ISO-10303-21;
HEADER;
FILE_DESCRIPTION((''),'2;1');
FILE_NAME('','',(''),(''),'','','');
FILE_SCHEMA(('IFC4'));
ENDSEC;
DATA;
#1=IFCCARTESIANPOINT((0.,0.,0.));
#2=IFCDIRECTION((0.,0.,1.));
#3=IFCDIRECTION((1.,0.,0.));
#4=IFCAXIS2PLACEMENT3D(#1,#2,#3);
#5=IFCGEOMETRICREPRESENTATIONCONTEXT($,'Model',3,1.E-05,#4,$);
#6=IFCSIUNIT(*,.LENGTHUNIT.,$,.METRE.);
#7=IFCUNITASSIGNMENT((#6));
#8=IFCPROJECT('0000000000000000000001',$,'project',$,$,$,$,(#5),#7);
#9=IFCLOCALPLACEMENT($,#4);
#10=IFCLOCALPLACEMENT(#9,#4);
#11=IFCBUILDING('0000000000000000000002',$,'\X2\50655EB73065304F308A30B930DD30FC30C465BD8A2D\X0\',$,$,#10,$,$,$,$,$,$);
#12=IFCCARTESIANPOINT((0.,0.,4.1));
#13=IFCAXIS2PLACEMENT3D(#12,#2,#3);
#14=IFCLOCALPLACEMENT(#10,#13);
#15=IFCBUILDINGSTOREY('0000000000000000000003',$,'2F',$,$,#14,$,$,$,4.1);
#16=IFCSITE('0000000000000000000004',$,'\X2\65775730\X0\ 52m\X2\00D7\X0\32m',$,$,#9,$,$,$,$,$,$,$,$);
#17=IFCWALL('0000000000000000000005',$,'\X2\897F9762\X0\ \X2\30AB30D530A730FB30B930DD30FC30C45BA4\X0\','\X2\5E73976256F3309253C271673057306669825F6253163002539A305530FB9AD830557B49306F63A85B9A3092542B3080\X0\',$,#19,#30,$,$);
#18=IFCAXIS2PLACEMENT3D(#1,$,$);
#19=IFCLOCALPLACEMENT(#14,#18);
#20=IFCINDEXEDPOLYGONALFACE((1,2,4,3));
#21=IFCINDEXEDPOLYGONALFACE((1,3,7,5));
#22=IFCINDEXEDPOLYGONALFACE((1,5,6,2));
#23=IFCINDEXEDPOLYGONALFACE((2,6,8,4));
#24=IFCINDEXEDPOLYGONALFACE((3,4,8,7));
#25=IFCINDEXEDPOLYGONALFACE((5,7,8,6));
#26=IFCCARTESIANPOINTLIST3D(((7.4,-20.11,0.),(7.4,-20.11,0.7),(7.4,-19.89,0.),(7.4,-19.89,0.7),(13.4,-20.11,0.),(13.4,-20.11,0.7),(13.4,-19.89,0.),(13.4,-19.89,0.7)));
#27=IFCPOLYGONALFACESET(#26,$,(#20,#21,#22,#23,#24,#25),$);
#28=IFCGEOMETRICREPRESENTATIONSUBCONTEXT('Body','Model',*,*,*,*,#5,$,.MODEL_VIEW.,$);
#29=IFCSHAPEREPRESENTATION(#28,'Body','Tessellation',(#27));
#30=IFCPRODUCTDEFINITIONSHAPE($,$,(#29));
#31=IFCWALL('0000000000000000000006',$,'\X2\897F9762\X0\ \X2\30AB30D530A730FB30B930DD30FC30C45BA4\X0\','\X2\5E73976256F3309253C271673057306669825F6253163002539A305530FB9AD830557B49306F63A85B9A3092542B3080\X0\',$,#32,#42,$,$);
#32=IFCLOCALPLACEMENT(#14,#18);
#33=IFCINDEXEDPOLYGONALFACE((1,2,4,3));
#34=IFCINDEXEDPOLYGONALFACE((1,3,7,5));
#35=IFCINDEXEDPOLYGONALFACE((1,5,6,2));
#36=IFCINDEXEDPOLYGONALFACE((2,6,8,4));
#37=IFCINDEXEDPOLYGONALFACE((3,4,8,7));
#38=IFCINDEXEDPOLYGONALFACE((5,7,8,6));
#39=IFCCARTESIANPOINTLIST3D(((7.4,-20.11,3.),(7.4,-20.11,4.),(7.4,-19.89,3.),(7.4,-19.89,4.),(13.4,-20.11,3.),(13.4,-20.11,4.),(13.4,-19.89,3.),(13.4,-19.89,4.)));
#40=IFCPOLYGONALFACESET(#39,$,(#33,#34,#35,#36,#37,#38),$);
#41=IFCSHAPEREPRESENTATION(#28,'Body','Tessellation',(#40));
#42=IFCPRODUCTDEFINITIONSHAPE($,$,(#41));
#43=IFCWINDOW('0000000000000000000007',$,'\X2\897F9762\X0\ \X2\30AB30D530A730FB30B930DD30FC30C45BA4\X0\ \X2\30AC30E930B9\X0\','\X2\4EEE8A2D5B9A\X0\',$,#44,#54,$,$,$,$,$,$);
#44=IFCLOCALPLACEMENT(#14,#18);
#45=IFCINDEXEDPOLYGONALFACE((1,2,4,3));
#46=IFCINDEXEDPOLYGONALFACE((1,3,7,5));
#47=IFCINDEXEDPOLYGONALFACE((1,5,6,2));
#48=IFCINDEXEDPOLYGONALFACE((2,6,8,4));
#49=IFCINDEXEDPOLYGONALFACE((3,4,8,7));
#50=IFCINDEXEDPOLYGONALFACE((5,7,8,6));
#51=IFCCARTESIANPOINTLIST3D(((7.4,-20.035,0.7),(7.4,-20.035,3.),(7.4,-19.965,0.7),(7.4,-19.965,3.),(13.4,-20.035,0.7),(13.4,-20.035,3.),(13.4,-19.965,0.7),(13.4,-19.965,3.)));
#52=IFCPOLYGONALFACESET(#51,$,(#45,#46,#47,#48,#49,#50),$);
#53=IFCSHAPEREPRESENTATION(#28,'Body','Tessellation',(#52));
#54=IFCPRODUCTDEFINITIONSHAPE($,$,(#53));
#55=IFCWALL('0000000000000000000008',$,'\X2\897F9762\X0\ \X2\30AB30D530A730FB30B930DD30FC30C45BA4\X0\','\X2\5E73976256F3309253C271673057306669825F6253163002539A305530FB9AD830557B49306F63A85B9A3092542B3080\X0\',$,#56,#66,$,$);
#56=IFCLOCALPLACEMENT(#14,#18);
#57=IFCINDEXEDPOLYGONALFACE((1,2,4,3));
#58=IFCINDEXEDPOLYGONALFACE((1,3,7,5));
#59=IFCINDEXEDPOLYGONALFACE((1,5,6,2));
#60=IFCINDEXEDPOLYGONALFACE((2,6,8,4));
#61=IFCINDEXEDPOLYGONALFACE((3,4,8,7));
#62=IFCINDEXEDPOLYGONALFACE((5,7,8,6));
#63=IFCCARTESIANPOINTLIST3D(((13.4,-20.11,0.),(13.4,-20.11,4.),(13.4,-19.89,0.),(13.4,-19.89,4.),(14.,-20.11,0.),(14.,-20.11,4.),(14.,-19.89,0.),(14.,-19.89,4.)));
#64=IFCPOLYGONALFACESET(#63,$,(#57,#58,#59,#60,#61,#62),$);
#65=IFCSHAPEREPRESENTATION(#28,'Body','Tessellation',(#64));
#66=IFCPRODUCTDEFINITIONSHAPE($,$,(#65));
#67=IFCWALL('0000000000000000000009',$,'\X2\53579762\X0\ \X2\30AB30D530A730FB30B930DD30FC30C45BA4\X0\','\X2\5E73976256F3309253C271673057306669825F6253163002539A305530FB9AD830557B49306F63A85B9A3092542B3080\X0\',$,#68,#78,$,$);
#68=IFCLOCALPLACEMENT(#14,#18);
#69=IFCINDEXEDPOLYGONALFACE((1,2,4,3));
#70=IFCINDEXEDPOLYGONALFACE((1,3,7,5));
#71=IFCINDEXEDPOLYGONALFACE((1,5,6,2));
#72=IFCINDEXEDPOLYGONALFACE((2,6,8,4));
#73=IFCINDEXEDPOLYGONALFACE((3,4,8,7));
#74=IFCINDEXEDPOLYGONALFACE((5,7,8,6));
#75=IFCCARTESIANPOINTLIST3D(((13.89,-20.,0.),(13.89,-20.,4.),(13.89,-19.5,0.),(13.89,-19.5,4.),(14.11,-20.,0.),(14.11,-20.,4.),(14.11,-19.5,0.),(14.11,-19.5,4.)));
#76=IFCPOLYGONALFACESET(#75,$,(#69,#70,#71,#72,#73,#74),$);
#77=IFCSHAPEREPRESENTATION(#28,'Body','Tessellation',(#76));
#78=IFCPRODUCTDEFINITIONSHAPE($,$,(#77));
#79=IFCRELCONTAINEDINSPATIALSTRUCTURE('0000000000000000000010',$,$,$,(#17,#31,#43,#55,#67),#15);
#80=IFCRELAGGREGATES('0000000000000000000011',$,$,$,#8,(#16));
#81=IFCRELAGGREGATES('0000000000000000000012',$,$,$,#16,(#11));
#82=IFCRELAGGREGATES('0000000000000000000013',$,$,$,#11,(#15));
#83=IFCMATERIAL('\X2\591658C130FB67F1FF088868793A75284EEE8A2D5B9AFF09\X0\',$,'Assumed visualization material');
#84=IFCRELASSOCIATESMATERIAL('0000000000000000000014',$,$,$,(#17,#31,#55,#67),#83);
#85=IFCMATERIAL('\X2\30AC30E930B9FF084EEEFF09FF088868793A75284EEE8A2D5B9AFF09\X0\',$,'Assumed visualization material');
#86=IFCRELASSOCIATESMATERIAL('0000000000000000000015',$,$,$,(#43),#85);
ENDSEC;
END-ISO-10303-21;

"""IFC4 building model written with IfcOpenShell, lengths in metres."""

from ifc_helpers import new_model, si_unit, frame, origin_with_axes, place, context, subcontext, project, spatial, rectangle, extrude, material, element, save


model = new_model("IFC4")

# Units and contexts
model_context = context("Model", 3, precision=1e-05, world=origin_with_axes())
body_context = subcontext(model_context, "Body", "Model", "MODEL_VIEW")
ifc_project = project(units=[si_unit("LENGTHUNIT", "METRE")], contexts=[model_context])

# Site, building, storey
site_placement = place(None, origin_with_axes())
site = spatial("IfcSite", under=ifc_project, at=site_placement, Name="敷地 52m×32m")
building_placement = place(site_placement, origin_with_axes())
building = spatial("IfcBuilding", under=site, at=building_placement, Name="健康づくりスポーツ施設")
storey_placement = place(building_placement, frame((0.0, 0.0, 4.1), z_axis=(0.0, 0.0, 1.0), x_axis=(1.0, 0.0, 0.0)))
storey = spatial("IfcBuildingStorey", under=building, at=storey_placement, Name="2F", Elevation=4.1)

# Shared definitions
ifc_material_1 = material(Name="ガラス（仮）（表示用仮設定）", Category="Assumed visualization material")

# Walls
ifc_material_2 = material(Name="外壁・柱（表示用仮設定）", Category="Assumed visualization material")
wall_1_placement = place(storey_placement, frame((10.4, -20.0, 0.0), z_axis=(0.0, 0.0, 1.0), x_axis=(1.0, 0.0, 0.0)))
element("IfcWall", 1, at=wall_1_placement, inside=storey, material=ifc_material_2, Name="西面 カフェ・スポーツ室", Description="平面図を参照して概形化。厚さ・高さ等は推定を含む", context=body_context, shape_type="SweptSolid", body=[
    extrude(rectangle(XDim=6.0, YDim=0.22), origin_with_axes(), (0.0, 0.0, 1.0), 0.7),
])
wall_2_placement = place(storey_placement, frame((10.4, -20.0, 3.0), z_axis=(0.0, 0.0, 1.0), x_axis=(1.0, 0.0, 0.0)))
element("IfcWall", 2, at=wall_2_placement, inside=storey, material=ifc_material_2, Name="西面 カフェ・スポーツ室", Description="平面図を参照して概形化。厚さ・高さ等は推定を含む", context=body_context, shape_type="SweptSolid", body=[
    extrude(rectangle(XDim=6.0, YDim=0.22), origin_with_axes(), (0.0, 0.0, 1.0), 1.0),
])

# Window
window_1_placement = place(storey_placement, frame((10.4, -20.0, 0.7), z_axis=(0.0, 0.0, 1.0), x_axis=(1.0, 0.0, 0.0)))
element("IfcWindow", 3, at=window_1_placement, inside=storey, material=ifc_material_1, Name="西面 カフェ・スポーツ室 ガラス", Description="仮設定", context=body_context, shape_type="SweptSolid", body=[
    extrude(rectangle(XDim=6.0, YDim=0.07), origin_with_axes(), (0.0, 0.0, 1.0), 2.3),
])

# Walls
wall_3_placement = place(storey_placement, frame((13.7, -20.0, 0.0), z_axis=(0.0, 0.0, 1.0), x_axis=(1.0, 0.0, 0.0)))
element("IfcWall", 4, at=wall_3_placement, inside=storey, material=ifc_material_2, Name="西面 カフェ・スポーツ室", Description="平面図を参照して概形化。厚さ・高さ等は推定を含む", context=body_context, shape_type="SweptSolid", body=[
    extrude(rectangle(XDim=0.6, YDim=0.22), origin_with_axes(), (0.0, 0.0, 1.0), 4.0),
])
wall_4_placement = place(storey_placement, frame((14.0, -19.75, 0.0), z_axis=(0.0, 0.0, 1.0), x_axis=(1.0, 0.0, 0.0)))
element("IfcWall", 5, at=wall_4_placement, inside=storey, material=ifc_material_2, Name="南面 カフェ・スポーツ室", Description="平面図を参照して概形化。厚さ・高さ等は推定を含む", context=body_context, shape_type="SweptSolid", body=[
    extrude(rectangle(XDim=0.22, YDim=0.5), origin_with_axes(), (0.0, 0.0, 1.0), 4.0),
])

save(model, "model.ifc")
